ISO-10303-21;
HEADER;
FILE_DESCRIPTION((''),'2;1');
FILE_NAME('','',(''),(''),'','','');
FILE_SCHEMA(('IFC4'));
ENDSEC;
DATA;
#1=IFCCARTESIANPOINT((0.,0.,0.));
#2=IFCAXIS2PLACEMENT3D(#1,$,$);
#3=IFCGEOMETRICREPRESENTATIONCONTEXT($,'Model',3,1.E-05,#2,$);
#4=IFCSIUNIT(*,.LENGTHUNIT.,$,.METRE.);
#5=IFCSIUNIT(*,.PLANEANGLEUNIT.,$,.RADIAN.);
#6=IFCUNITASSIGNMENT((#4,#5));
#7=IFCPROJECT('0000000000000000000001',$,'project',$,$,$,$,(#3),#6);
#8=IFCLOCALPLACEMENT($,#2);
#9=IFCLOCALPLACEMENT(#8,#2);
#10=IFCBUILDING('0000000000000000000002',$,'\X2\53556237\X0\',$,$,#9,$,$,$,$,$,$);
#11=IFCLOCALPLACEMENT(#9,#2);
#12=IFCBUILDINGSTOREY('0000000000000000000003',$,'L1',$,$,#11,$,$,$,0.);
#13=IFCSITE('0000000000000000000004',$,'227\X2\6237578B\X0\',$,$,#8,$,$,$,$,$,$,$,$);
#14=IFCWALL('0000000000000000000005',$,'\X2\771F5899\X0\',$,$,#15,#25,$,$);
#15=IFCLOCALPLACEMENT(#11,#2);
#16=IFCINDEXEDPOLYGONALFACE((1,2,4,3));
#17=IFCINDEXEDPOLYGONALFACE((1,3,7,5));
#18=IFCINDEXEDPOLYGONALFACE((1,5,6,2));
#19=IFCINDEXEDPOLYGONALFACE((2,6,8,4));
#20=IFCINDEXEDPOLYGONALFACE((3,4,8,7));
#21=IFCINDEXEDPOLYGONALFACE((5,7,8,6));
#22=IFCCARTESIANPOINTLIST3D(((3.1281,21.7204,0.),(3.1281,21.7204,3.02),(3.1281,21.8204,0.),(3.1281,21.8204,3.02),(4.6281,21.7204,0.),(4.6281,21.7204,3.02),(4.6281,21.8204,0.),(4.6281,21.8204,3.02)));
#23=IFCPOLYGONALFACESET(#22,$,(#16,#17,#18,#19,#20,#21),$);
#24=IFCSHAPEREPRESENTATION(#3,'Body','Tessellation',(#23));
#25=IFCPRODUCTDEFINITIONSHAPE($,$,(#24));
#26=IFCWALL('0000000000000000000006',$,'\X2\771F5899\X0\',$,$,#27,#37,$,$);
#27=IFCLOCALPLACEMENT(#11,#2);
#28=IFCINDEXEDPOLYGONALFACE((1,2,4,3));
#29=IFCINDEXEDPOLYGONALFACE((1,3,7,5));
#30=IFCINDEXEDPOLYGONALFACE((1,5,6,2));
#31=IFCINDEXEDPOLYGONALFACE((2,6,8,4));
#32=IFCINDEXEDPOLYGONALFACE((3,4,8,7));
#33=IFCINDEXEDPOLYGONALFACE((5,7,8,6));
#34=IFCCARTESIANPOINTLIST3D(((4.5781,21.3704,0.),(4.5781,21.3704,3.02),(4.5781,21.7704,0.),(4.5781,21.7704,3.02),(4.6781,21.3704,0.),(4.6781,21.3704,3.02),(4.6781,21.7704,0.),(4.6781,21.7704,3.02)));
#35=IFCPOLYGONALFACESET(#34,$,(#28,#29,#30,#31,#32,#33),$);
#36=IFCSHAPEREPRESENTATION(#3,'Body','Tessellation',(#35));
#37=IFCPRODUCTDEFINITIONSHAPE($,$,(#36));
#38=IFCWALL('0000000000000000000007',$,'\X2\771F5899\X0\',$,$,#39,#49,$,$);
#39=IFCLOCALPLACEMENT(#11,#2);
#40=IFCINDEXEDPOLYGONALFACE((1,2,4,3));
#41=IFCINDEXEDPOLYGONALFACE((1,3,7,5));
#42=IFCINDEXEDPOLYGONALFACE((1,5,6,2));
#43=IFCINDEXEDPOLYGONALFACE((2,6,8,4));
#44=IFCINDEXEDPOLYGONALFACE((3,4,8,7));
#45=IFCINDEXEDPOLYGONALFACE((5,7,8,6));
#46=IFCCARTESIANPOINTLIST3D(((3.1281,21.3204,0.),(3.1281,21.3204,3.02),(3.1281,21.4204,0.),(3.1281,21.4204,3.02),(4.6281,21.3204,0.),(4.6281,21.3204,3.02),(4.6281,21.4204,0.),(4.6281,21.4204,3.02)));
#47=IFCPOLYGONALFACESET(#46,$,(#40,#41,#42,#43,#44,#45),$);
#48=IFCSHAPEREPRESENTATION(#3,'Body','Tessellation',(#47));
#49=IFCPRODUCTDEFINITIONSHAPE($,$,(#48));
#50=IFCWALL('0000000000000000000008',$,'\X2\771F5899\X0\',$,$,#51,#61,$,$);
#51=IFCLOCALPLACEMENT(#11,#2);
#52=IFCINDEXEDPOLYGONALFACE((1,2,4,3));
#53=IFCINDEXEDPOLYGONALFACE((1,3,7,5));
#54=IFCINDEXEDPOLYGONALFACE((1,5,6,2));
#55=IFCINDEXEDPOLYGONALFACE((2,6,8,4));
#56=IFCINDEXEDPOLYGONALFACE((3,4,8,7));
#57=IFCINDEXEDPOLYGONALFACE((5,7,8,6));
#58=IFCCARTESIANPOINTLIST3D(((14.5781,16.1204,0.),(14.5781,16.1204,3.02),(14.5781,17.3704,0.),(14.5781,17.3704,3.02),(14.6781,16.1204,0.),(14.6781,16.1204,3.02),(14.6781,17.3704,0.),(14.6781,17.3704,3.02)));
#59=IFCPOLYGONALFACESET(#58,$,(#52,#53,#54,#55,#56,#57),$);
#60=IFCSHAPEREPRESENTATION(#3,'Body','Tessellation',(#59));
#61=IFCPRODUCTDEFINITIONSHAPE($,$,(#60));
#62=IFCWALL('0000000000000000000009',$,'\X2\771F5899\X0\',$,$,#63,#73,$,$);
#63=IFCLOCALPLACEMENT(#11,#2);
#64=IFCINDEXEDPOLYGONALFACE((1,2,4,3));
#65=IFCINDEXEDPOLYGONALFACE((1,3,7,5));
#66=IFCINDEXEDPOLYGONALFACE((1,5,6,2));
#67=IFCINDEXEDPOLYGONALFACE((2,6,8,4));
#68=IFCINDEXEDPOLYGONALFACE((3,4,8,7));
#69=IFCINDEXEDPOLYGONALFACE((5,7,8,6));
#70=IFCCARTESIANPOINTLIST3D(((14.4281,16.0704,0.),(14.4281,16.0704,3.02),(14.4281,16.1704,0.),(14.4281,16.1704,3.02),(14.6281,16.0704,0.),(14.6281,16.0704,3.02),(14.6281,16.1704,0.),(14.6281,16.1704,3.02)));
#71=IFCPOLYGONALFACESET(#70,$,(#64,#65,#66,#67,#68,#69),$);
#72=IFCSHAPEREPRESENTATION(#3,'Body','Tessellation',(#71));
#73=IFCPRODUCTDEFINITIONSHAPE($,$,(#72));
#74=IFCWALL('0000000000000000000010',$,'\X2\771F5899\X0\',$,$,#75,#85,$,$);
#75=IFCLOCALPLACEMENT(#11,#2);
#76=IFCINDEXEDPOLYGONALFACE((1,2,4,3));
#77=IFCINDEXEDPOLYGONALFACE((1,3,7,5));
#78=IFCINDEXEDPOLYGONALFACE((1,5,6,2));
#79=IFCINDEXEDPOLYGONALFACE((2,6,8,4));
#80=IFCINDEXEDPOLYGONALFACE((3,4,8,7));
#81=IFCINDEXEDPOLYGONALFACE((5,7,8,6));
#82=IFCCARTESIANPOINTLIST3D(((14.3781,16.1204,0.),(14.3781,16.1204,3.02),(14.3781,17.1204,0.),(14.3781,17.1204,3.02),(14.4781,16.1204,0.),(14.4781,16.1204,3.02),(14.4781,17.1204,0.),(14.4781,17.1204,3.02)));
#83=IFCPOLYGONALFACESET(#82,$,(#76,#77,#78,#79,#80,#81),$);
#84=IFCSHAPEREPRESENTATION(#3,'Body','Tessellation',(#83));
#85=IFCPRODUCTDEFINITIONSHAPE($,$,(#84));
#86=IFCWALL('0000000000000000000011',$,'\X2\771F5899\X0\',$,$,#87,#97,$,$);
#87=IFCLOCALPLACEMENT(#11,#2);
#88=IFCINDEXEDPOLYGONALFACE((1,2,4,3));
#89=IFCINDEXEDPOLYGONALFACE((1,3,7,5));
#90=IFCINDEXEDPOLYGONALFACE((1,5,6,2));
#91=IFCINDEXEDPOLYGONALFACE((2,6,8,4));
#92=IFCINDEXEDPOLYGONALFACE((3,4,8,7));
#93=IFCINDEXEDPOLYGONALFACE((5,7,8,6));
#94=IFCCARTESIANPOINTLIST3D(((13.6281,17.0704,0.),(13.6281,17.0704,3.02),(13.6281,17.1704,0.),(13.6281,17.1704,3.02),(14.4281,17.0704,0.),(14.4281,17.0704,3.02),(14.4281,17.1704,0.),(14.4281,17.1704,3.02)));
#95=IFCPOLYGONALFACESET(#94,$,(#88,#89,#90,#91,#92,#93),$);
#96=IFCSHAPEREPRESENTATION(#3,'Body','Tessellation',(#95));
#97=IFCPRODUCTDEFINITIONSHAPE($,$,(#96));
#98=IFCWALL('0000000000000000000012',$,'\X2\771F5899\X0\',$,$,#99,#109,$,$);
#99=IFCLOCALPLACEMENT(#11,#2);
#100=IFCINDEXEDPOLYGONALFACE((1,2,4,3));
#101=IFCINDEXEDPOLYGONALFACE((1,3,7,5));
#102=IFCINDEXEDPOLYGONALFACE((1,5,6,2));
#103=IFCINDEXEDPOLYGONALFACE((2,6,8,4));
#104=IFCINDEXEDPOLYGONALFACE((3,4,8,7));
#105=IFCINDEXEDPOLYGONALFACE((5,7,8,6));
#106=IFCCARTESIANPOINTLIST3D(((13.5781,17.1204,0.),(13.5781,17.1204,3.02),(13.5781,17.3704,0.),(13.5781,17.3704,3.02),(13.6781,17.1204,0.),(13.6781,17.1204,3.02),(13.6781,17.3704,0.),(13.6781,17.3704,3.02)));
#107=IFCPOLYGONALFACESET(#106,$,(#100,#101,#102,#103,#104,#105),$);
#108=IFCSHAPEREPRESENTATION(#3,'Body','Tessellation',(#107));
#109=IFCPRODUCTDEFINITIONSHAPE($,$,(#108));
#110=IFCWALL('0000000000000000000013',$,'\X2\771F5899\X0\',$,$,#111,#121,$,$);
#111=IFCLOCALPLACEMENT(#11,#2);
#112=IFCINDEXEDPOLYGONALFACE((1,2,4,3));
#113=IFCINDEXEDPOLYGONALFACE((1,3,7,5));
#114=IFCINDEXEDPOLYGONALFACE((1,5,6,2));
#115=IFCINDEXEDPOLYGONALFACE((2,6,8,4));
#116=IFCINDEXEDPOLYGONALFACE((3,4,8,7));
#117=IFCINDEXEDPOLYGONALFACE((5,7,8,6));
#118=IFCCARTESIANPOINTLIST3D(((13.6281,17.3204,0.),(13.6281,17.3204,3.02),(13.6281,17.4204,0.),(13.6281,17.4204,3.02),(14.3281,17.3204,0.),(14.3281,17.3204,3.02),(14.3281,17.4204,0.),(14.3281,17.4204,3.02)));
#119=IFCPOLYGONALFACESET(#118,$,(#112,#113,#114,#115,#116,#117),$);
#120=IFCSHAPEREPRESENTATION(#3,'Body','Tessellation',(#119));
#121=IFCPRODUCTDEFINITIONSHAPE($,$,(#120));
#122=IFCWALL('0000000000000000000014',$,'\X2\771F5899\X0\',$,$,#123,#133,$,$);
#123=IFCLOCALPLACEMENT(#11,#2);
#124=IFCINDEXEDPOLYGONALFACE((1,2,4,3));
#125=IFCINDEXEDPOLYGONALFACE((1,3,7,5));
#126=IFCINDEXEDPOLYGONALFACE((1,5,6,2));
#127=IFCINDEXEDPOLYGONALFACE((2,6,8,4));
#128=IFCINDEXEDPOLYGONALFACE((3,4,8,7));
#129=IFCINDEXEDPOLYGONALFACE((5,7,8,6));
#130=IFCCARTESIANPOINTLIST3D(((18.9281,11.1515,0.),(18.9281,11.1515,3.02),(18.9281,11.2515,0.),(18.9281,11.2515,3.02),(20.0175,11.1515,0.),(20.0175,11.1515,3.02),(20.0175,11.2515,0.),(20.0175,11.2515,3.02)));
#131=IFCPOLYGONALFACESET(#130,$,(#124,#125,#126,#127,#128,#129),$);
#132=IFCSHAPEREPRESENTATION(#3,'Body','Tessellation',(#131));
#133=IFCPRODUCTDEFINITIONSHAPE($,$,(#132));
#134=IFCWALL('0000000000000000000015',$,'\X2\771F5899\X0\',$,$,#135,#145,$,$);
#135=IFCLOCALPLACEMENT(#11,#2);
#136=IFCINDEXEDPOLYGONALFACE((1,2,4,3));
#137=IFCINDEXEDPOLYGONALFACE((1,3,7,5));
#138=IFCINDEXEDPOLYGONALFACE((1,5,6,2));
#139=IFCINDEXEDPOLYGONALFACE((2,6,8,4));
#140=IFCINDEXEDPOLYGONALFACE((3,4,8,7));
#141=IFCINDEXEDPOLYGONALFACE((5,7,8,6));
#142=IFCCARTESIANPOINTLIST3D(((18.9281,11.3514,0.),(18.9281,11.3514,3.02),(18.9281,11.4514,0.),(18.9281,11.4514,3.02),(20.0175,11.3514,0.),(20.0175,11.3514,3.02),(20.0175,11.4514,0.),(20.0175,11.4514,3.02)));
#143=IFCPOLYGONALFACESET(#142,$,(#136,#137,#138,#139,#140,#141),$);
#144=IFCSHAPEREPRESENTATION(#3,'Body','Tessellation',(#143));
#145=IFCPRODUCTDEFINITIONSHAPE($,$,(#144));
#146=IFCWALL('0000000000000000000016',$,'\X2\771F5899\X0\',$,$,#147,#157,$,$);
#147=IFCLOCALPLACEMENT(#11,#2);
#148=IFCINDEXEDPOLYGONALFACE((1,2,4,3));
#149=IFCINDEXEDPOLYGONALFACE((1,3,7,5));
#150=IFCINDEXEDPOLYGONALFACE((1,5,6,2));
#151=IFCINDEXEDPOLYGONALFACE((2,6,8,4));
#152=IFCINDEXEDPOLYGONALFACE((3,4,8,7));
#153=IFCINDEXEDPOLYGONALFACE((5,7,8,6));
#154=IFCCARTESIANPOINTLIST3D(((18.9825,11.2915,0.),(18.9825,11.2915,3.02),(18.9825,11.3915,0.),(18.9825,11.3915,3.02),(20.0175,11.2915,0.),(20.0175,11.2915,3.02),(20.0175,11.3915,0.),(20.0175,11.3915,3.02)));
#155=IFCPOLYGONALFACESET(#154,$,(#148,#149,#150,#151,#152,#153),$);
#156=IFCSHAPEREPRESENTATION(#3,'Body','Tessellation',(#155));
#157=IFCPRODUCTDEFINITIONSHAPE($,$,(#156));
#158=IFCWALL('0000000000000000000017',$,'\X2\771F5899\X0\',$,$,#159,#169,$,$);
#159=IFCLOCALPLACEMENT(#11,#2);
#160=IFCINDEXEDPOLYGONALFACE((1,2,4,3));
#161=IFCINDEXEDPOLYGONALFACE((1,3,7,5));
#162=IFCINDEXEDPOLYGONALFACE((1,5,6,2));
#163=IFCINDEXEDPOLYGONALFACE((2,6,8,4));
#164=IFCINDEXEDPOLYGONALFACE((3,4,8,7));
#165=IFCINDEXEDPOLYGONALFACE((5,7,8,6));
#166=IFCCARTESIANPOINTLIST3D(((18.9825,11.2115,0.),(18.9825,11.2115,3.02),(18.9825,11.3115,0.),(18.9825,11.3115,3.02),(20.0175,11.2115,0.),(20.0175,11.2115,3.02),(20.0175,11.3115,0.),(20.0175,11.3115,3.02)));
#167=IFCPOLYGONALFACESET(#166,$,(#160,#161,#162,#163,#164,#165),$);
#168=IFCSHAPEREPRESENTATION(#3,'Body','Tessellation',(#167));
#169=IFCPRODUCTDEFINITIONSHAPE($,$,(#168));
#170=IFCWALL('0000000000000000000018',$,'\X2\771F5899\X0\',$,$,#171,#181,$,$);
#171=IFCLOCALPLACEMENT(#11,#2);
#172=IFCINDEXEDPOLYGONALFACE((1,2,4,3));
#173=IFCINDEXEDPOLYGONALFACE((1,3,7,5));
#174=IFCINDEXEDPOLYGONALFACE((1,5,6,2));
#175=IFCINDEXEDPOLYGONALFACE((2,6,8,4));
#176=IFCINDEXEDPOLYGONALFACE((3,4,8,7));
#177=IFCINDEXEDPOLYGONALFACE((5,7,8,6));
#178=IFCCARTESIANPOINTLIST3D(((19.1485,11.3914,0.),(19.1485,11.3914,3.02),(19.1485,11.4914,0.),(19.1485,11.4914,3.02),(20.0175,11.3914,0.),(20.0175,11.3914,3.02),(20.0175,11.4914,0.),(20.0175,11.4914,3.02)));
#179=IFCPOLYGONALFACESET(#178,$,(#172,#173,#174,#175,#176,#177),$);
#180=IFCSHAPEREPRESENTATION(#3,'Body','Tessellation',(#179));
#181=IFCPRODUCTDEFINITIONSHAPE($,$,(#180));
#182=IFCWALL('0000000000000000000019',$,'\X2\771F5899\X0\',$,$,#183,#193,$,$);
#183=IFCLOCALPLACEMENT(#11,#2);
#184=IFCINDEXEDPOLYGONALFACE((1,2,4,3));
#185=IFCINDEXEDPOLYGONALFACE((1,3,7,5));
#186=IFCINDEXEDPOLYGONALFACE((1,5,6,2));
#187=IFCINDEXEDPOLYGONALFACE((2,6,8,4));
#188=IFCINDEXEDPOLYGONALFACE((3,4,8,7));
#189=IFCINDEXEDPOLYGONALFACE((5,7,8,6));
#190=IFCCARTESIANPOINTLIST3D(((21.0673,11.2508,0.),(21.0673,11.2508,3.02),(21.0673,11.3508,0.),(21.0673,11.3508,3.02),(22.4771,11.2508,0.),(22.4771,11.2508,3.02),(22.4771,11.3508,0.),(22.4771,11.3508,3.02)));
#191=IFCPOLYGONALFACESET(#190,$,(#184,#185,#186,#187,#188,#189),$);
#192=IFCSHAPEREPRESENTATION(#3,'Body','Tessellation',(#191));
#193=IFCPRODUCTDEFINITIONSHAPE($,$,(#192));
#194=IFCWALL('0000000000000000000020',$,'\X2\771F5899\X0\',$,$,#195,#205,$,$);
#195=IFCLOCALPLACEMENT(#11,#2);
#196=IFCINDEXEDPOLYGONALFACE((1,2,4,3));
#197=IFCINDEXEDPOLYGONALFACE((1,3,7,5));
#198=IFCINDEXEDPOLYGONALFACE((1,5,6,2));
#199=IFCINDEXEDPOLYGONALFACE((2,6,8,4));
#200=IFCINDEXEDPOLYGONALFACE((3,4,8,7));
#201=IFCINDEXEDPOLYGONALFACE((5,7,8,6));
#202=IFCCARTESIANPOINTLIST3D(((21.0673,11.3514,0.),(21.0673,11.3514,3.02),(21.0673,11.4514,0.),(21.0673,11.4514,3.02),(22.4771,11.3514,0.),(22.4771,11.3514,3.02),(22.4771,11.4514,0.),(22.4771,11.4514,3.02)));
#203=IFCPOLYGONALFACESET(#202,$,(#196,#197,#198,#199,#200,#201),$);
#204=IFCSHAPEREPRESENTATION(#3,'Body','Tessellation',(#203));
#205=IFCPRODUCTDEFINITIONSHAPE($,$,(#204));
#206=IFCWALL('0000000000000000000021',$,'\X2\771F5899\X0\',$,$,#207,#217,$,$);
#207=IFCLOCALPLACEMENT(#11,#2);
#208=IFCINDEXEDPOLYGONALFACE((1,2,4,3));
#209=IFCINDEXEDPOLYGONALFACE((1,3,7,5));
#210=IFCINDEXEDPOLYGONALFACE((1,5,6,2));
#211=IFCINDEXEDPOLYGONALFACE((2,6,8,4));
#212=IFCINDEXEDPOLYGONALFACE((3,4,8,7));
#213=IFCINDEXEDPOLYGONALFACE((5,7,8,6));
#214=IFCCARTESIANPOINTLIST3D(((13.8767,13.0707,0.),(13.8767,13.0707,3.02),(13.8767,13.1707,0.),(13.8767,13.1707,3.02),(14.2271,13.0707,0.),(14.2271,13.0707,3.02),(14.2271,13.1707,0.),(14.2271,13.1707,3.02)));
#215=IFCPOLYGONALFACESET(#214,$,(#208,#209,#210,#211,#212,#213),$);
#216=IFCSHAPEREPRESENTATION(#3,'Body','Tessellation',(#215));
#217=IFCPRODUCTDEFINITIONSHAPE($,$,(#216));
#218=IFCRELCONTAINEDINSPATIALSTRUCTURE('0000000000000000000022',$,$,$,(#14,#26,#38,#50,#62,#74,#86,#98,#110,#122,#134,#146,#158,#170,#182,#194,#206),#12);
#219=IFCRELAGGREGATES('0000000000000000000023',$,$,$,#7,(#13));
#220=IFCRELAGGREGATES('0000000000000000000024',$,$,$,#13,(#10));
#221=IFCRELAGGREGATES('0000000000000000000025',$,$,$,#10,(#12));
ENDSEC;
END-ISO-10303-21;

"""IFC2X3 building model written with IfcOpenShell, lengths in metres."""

from ifc_helpers import new_model, si_unit, origin, place, context, project, spatial, polyline, outline, extrude, element, save


model = new_model("IFC2X3")

# Units and contexts
model_context = context("Model", 3, precision=1e-05, world=origin())
ifc_project = project(units=[si_unit("LENGTHUNIT", "METRE"), si_unit("PLANEANGLEUNIT", "RADIAN")], contexts=[model_context])

# Site, building, storey
site_placement = place(None, origin())
site = spatial("IfcSite", under=ifc_project, at=site_placement, Name="227户型")
building_placement = place(site_placement, origin())
building = spatial("IfcBuilding", under=site, at=building_placement, Name="单户")
storey_placement = place(building_placement, origin())
storey = spatial("IfcBuildingStorey", under=building, at=storey_placement, Name="L1", Elevation=0.0)

# Walls
wall_1_placement = place(storey_placement, origin())
element("IfcWall", 1, at=wall_1_placement, inside=storey, Name="真墙", context=model_context, shape_type="SweptSolid", body=[
    extrude(outline(polyline([(3.1281, 21.8204), (4.6281, 21.8204), (4.6281, 21.7204), (3.1281, 21.7204), (3.1281, 21.8204)])), origin(), (0.0, 0.0, 1.0), 3.02),
])
wall_2_placement = place(storey_placement, origin())
element("IfcWall", 2, at=wall_2_placement, inside=storey, Name="真墙", context=model_context, shape_type="SweptSolid", body=[
    extrude(outline(polyline([(4.6781, 21.7704), (4.6781, 21.3704), (4.5781, 21.3704), (4.5781, 21.7704), (4.6781, 21.7704)])), origin(), (0.0, 0.0, 1.0), 3.02),
])
wall_3_placement = place(storey_placement, origin())
element("IfcWall", 3, at=wall_3_placement, inside=storey, Name="真墙", context=model_context, shape_type="SweptSolid", body=[
    extrude(outline(polyline([(4.6281, 21.3204), (3.1281, 21.3204), (3.1281, 21.4204), (4.6281, 21.4204), (4.6281, 21.3204)])), origin(), (0.0, 0.0, 1.0), 3.02),
])
wall_4_placement = place(storey_placement, origin())
element("IfcWall", 4, at=wall_4_placement, inside=storey, Name="真墙", context=model_context, shape_type="SweptSolid", body=[
    extrude(outline(polyline([(14.6781, 17.3704), (14.6781, 16.1204), (14.5781, 16.1204), (14.5781, 17.3704), (14.6781, 17.3704)])), origin(), (0.0, 0.0, 1.0), 3.02),
])
wall_5_placement = place(storey_placement, origin())
element("IfcWall", 5, at=wall_5_placement, inside=storey, Name="真墙", context=model_context, shape_type="SweptSolid", body=[
    extrude(outline(polyline([(14.6281, 16.0704), (14.4281, 16.0704), (14.4281, 16.1704), (14.6281, 16.1704), (14.6281, 16.0704)])), origin(), (0.0, 0.0, 1.0), 3.02),
])
wall_6_placement = place(storey_placement, origin())
element("IfcWall", 6, at=wall_6_placement, inside=storey, Name="真墙", context=model_context, shape_type="SweptSolid", body=[
    extrude(outline(polyline([(14.3781, 16.1204), (14.3781, 17.1204), (14.4781, 17.1204), (14.4781, 16.1204), (14.3781, 16.1204)])), origin(), (0.0, 0.0, 1.0), 3.02),
])
wall_7_placement = place(storey_placement, origin())
element("IfcWall", 7, at=wall_7_placement, inside=storey, Name="真墙", context=model_context, shape_type="SweptSolid", body=[
    extrude(outline(polyline([(14.4281, 17.0704), (13.6281, 17.0704), (13.6281, 17.1704), (14.4281, 17.1704), (14.4281, 17.0704)])), origin(), (0.0, 0.0, 1.0), 3.02),
])
wall_8_placement = place(storey_placement, origin())
element("IfcWall", 8, at=wall_8_placement, inside=storey, Name="真墙", context=model_context, shape_type="SweptSolid", body=[
    extrude(outline(polyline([(13.5781, 17.1204), (13.5781, 17.3704), (13.6781, 17.3704), (13.6781, 17.1204), (13.5781, 17.1204)])), origin(), (0.0, 0.0, 1.0), 3.02),
])
wall_9_placement = place(storey_placement, origin())
element("IfcWall", 9, at=wall_9_placement, inside=storey, Name="真墙", context=model_context, shape_type="SweptSolid", body=[
    extrude(outline(polyline([(13.6281, 17.4204), (14.3281, 17.4204), (14.3281, 17.3204), (13.6281, 17.3204), (13.6281, 17.4204)])), origin(), (0.0, 0.0, 1.0), 3.02),
])

# Walls
wall_10_placement = place(storey_placement, origin())
element("IfcWall", 10, at=wall_10_placement, inside=storey, Name="真墙", context=model_context, shape_type="SweptSolid", body=[
    extrude(outline(polyline([(20.0175, 11.1515), (18.9281, 11.1515), (18.9281, 11.2515), (20.0175, 11.2515), (20.0175, 11.1515)])), origin(), (0.0, 0.0, 1.0), 3.02),
])
wall_11_placement = place(storey_placement, origin())
element("IfcWall", 11, at=wall_11_placement, inside=storey, Name="真墙", context=model_context, shape_type="SweptSolid", body=[
    extrude(outline(polyline([(18.9281, 11.4514), (20.0175, 11.4514), (20.0175, 11.3514), (18.9281, 11.3514), (18.9281, 11.4514)])), origin(), (0.0, 0.0, 1.0), 3.02),
])
wall_12_placement = place(storey_placement, origin())
element("IfcWall", 12, at=wall_12_placement, inside=storey, Name="真墙", context=model_context, shape_type="SweptSolid", body=[
    extrude(outline(polyline([(20.0175, 11.2915), (18.9825, 11.2915), (18.9825, 11.3915), (20.0175, 11.3915), (20.0175, 11.2915)])), origin(), (0.0, 0.0, 1.0), 3.02),
])
wall_13_placement = place(storey_placement, origin())
element("IfcWall", 13, at=wall_13_placement, inside=storey, Name="真墙", context=model_context, shape_type="SweptSolid", body=[
    extrude(outline(polyline([(18.9825, 11.3115), (20.0175, 11.3115), (20.0175, 11.2115), (18.9825, 11.2115), (18.9825, 11.3115)])), origin(), (0.0, 0.0, 1.0), 3.02),
])
wall_14_placement = place(storey_placement, origin())
element("IfcWall", 14, at=wall_14_placement, inside=storey, Name="真墙", context=model_context, shape_type="SweptSolid", body=[
    extrude(outline(polyline([(20.0175, 11.3914), (19.1485, 11.3914), (19.1485, 11.4914), (20.0175, 11.4914), (20.0175, 11.3914)])), origin(), (0.0, 0.0, 1.0), 3.02),
])
wall_15_placement = place(storey_placement, origin())
element("IfcWall", 15, at=wall_15_placement, inside=storey, Name="真墙", context=model_context, shape_type="SweptSolid", body=[
    extrude(outline(polyline([(21.0673, 11.3508), (22.4771, 11.3508), (22.4771, 11.2508), (21.0673, 11.2508), (21.0673, 11.3508)])), origin(), (0.0, 0.0, 1.0), 3.02),
])
wall_16_placement = place(storey_placement, origin())
element("IfcWall", 16, at=wall_16_placement, inside=storey, Name="真墙", context=model_context, shape_type="SweptSolid", body=[
    extrude(outline(polyline([(22.4771, 11.3514), (21.0673, 11.3514), (21.0673, 11.4514), (22.4771, 11.4514), (22.4771, 11.3514)])), origin(), (0.0, 0.0, 1.0), 3.02),
])
wall_17_placement = place(storey_placement, origin())
element("IfcWall", 17, at=wall_17_placement, inside=storey, Name="真墙", context=model_context, shape_type="SweptSolid", body=[
    extrude(outline(polyline([(14.2271, 13.0707), (13.8767, 13.0707), (13.8767, 13.1707), (14.2271, 13.1707), (14.2271, 13.0707)])), origin(), (0.0, 0.0, 1.0), 3.02),
])

save(model, "model.ifc")
